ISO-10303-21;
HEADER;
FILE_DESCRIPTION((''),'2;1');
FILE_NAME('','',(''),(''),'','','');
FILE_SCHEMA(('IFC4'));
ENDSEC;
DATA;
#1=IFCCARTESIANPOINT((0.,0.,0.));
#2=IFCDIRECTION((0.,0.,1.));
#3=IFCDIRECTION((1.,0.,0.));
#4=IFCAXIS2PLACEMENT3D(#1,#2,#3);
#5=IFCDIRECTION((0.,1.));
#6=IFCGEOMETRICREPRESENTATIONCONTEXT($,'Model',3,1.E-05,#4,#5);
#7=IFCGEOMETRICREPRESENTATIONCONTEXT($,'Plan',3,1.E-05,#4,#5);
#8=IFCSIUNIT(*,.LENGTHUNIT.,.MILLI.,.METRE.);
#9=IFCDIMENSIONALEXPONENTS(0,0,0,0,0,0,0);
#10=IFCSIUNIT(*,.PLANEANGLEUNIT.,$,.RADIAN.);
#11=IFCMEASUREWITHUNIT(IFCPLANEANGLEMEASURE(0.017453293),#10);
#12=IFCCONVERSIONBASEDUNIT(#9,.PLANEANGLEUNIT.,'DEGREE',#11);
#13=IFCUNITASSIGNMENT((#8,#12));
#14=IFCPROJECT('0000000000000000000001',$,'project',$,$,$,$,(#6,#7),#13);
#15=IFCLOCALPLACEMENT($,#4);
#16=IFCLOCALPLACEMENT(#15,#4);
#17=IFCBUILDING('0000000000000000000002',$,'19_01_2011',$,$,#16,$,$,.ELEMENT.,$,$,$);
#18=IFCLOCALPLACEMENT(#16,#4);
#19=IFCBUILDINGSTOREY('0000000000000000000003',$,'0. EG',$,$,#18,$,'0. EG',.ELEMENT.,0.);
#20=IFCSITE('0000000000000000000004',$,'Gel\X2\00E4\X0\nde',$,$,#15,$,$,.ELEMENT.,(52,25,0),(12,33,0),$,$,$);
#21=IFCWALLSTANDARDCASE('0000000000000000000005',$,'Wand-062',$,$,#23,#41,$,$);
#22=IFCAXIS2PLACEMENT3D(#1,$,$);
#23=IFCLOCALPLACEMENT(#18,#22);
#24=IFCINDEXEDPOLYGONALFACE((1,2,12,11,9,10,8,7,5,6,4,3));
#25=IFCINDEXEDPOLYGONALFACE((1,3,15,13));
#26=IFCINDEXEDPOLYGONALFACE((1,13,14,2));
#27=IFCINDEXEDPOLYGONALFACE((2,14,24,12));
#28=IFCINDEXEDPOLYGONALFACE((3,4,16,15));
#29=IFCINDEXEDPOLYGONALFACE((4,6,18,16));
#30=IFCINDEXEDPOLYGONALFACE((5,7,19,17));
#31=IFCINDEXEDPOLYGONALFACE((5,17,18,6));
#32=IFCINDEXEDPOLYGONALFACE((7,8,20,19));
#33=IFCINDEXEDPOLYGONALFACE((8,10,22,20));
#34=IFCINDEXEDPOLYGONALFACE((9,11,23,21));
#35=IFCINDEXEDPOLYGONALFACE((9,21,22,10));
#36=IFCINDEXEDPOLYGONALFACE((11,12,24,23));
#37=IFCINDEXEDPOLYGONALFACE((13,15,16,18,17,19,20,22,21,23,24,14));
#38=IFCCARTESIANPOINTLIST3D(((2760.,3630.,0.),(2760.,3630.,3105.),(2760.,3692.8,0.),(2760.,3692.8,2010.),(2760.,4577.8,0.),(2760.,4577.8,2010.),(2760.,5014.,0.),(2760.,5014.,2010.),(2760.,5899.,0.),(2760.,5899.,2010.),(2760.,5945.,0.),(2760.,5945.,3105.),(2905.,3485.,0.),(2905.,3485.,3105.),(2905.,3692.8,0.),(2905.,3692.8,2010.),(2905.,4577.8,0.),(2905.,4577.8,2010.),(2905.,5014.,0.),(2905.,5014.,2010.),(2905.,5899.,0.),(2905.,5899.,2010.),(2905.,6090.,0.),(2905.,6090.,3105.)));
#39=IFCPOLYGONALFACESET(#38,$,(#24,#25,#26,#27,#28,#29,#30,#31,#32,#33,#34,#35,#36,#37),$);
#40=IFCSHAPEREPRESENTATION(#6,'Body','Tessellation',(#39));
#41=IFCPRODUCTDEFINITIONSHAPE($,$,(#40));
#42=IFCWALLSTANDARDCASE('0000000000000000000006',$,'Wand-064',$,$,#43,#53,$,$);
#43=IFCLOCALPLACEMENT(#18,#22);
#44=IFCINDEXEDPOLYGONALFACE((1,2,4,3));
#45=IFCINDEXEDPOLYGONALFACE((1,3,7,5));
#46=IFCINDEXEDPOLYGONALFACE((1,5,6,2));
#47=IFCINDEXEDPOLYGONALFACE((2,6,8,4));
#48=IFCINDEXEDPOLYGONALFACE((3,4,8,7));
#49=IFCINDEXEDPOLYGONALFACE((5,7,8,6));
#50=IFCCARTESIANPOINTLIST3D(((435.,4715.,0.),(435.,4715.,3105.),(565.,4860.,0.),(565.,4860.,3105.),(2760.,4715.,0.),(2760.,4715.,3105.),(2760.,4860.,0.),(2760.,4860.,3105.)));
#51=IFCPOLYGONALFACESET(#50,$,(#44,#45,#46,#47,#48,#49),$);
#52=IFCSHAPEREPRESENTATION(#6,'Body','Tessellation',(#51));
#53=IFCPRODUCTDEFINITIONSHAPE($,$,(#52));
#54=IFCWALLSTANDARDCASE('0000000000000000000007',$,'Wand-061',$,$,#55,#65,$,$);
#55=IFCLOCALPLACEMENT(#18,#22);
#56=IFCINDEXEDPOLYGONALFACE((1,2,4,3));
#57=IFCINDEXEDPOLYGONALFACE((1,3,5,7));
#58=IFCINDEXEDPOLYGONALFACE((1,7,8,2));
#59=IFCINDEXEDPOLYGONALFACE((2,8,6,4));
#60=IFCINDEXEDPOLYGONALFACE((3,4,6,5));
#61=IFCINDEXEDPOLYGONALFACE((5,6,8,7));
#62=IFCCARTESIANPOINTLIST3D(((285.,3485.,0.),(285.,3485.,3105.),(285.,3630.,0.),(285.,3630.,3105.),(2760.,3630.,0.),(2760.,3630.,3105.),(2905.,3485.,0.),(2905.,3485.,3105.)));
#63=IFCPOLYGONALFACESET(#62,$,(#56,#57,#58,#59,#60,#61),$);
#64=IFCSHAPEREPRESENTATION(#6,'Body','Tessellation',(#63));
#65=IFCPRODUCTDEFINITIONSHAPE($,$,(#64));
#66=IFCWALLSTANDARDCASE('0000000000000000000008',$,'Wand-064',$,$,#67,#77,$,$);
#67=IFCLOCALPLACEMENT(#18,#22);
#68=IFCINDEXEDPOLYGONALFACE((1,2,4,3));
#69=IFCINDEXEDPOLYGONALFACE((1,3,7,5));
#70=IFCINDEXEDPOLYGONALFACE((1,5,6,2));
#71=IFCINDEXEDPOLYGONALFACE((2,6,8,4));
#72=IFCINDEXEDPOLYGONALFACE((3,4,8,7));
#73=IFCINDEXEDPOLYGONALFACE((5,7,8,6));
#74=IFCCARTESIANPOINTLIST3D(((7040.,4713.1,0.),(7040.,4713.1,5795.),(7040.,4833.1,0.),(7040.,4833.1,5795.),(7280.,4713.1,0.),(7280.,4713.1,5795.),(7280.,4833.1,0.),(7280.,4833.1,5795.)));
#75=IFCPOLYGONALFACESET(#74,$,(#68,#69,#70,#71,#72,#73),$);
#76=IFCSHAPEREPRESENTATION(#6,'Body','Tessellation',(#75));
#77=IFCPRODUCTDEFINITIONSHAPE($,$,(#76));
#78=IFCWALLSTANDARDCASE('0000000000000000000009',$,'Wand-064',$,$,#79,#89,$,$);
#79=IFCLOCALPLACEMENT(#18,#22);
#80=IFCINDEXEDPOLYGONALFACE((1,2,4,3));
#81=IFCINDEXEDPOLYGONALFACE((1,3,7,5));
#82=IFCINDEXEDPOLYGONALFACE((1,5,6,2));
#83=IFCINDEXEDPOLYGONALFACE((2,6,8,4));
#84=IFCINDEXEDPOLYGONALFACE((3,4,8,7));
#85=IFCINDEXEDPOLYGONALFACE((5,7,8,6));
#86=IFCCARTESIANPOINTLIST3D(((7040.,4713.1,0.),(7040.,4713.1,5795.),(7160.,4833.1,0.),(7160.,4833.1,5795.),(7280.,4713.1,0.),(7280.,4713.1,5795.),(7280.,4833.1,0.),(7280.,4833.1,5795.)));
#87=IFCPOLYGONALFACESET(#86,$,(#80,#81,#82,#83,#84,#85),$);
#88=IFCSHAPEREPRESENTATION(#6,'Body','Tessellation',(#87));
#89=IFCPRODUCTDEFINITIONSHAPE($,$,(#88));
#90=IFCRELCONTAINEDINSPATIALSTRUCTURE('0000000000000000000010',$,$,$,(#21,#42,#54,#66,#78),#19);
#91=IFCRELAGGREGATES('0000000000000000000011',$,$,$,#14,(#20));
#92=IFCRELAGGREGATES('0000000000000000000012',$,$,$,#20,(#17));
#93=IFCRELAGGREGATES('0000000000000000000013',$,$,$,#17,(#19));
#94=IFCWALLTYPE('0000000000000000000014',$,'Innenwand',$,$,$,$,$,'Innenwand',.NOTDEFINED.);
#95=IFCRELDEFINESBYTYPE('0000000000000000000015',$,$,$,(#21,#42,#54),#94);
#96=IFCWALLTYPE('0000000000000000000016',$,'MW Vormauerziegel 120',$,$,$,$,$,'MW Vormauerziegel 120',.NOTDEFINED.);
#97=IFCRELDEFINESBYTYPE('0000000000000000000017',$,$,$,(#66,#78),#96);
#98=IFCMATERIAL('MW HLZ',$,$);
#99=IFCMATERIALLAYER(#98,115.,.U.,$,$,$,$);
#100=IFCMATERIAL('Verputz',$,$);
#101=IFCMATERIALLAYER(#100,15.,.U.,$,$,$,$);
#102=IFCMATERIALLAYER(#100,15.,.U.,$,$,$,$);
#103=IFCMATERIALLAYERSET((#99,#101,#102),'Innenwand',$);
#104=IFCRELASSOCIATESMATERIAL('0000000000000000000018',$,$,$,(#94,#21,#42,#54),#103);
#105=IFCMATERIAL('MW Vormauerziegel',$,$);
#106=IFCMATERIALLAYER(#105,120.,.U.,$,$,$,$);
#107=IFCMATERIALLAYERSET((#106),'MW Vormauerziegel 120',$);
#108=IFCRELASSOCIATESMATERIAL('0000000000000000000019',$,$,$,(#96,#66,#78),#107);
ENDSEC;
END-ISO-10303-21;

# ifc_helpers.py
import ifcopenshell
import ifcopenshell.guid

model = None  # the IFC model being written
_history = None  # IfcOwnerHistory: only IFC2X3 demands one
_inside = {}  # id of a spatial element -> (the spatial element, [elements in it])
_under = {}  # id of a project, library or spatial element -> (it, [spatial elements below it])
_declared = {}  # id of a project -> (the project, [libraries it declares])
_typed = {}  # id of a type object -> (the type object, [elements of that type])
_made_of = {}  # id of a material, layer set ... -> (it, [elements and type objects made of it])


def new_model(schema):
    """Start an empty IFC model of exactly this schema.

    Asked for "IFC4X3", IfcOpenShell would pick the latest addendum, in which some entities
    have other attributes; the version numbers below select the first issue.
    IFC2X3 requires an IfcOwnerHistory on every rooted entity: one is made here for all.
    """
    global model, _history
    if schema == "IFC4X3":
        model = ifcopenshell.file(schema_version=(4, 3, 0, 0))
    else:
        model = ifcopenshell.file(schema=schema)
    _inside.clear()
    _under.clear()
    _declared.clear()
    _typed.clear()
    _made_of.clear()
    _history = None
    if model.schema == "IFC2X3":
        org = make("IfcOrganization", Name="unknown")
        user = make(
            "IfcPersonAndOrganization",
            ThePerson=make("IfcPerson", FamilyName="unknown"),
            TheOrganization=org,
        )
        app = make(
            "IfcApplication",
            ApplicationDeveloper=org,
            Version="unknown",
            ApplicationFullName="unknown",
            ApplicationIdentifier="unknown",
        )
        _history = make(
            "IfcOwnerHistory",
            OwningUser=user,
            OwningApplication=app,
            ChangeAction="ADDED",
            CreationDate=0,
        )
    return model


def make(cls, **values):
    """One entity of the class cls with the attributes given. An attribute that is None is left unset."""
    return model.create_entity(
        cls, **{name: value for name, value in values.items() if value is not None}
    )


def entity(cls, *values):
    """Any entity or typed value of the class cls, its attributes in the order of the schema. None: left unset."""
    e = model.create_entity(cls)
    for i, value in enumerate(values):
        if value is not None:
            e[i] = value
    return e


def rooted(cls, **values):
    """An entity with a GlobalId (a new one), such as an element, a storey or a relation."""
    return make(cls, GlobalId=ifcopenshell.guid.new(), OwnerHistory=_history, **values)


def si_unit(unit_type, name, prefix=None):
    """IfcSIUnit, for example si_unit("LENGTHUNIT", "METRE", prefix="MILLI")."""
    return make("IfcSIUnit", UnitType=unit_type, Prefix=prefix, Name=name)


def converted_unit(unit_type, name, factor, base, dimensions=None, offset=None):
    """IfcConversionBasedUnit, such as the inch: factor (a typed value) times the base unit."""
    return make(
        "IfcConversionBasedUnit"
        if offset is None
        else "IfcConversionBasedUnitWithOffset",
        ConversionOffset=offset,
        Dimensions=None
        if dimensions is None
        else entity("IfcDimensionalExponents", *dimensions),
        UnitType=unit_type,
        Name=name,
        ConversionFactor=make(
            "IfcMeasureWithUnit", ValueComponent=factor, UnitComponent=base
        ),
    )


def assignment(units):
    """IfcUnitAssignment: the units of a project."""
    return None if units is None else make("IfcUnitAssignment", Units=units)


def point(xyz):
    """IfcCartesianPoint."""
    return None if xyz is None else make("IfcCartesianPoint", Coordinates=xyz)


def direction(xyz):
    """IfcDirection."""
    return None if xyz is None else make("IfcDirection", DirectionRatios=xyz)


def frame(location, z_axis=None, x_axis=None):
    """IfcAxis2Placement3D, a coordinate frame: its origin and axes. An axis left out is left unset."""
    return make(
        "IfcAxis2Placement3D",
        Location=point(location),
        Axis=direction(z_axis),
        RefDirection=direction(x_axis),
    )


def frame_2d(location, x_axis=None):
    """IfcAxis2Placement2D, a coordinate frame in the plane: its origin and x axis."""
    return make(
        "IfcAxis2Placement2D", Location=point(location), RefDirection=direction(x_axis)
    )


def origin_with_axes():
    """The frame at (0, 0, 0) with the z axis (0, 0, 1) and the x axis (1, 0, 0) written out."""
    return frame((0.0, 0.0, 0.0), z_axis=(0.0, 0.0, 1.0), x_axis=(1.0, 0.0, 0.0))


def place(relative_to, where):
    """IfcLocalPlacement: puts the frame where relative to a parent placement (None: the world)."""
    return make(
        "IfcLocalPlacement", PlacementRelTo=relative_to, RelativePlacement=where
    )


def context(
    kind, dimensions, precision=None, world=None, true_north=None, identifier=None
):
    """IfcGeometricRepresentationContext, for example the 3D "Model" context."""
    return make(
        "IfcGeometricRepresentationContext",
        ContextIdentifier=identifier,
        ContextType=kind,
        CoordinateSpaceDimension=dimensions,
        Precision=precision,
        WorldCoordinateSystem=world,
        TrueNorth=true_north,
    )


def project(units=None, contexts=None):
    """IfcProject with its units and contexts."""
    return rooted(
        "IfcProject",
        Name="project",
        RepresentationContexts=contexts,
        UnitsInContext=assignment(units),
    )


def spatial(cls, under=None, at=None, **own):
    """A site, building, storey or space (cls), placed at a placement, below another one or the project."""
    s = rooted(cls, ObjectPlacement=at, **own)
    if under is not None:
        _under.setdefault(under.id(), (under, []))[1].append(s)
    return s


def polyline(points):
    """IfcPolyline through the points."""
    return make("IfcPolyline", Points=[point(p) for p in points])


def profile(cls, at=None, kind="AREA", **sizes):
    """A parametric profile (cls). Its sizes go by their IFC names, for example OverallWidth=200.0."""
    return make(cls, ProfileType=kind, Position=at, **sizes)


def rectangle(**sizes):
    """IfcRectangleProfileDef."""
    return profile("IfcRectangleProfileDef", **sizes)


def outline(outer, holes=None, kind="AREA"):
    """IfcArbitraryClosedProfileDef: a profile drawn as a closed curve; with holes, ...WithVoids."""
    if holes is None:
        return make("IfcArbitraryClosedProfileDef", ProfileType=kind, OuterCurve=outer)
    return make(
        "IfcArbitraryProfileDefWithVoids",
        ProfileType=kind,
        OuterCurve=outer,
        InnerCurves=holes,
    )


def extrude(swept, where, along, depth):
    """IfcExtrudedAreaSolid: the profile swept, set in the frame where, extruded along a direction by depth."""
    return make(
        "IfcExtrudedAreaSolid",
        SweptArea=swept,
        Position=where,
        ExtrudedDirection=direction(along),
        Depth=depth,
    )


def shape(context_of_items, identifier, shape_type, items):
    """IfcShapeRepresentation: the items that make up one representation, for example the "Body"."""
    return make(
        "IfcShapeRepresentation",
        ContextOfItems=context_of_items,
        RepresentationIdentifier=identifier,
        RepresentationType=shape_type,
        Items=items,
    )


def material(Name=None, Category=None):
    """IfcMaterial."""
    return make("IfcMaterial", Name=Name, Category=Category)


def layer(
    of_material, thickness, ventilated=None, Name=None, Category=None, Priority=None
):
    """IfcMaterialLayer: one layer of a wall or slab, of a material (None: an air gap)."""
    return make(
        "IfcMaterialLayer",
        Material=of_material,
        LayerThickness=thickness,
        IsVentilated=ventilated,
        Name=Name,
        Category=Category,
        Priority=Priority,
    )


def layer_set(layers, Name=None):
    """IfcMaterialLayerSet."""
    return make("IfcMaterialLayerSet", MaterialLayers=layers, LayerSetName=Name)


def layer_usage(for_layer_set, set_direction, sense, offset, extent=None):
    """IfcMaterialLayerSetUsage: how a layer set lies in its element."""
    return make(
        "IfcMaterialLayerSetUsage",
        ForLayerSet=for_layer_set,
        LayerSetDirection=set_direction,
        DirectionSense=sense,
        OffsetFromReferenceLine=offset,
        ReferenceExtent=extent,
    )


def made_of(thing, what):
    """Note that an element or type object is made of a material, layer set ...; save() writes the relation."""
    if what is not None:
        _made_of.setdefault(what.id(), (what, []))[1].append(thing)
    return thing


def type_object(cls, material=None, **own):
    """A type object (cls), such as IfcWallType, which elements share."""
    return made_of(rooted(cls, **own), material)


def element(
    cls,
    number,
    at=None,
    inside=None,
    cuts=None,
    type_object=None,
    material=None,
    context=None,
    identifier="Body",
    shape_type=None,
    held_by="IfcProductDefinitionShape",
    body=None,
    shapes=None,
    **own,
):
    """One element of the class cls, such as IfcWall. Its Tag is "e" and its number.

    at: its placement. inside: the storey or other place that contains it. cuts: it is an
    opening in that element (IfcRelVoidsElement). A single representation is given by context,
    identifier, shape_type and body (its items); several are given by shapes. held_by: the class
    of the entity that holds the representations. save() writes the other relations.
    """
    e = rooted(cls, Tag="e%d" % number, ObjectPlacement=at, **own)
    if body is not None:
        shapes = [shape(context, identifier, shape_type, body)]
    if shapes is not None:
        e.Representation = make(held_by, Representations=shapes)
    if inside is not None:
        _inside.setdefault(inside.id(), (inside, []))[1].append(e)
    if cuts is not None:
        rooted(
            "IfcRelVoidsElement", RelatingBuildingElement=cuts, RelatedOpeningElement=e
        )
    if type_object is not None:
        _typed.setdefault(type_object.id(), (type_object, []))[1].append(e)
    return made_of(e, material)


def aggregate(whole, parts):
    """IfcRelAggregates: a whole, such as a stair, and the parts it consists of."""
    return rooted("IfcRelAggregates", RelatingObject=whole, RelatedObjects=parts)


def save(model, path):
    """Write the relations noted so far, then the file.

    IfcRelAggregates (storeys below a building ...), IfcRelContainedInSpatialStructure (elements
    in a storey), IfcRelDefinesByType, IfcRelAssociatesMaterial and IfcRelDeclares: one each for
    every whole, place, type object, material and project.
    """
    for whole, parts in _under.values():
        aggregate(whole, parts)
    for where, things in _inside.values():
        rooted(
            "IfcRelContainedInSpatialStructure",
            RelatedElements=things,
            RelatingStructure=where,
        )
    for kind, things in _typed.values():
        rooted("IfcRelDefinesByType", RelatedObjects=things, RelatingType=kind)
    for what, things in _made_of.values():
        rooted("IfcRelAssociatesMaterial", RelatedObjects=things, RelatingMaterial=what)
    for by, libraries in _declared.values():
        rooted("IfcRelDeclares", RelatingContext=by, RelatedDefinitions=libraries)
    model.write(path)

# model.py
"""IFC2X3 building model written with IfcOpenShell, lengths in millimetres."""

from ifc_helpers import new_model, entity, si_unit, converted_unit, direction, frame, frame_2d, origin_with_axes, place, context, project, spatial, polyline, rectangle, outline, extrude, material, layer, layer_set, layer_usage, type_object, element, save


model = new_model("IFC2X3")

# Units and contexts
model_context = context("Model", 3, precision=1e-05, world=origin_with_axes(), true_north=direction((0.0, 1.0)))
plan_context = context("Plan", 3, precision=1e-05, world=origin_with_axes(), true_north=direction((0.0, 1.0)))
ifc_project = project(units=[si_unit("LENGTHUNIT", "METRE", prefix="MILLI"), converted_unit("PLANEANGLEUNIT", "DEGREE", entity("IfcPlaneAngleMeasure", 0.017453293), si_unit("PLANEANGLEUNIT", "RADIAN"), dimensions=[0, 0, 0, 0, 0, 0, 0])], contexts=[model_context, plan_context])

# Site, building, storey
site_placement = place(None, origin_with_axes())
site = spatial("IfcSite", under=ifc_project, at=site_placement, Name="Gelände", CompositionType="ELEMENT", RefLatitude=(52, 25, 0), RefLongitude=(12, 33, 0))
building_placement = place(site_placement, origin_with_axes())
building = spatial("IfcBuilding", under=site, at=building_placement, Name="19_01_2011", CompositionType="ELEMENT")
storey_placement = place(building_placement, origin_with_axes())
storey = spatial("IfcBuildingStorey", under=building, at=storey_placement, Name="0. EG", LongName="0. EG", CompositionType="ELEMENT", Elevation=0.0)

# Shared definitions
ifc_material_1 = material(Name="MW HLZ")
ifc_material_2 = material(Name="Verputz")

# Wall, openings
ifc_material_3 = material(Name="MW Vormauerziegel")
ifc_layer_1 = layer(ifc_material_1, 115.0, ventilated="UNKNOWN")
ifc_layer_2 = layer(ifc_material_2, 15.0, ventilated="UNKNOWN")
ifc_layer_3 = layer(ifc_material_2, 15.0, ventilated="UNKNOWN")
ifc_layer_set_1 = layer_set([ifc_layer_1, ifc_layer_2, ifc_layer_3], Name="Innenwand")
ifc_layer_usage_1 = layer_usage(ifc_layer_set_1, "AXIS2", "NEGATIVE", 0.0)
wall_type_1 = type_object("IfcWallType", Name="Innenwand", ElementType="Innenwand", PredefinedType="NOTDEFINED", material=ifc_layer_set_1)
wall_1_placement = place(storey_placement, frame((2760.0, 3630.0, 0.0), z_axis=(0.0, 0.0, 1.0), x_axis=(0.0, 1.0, 0.0)))
wall_1 = element("IfcWallStandardCase", 1, at=wall_1_placement, inside=storey, type_object=wall_type_1, material=ifc_layer_usage_1, Name="Wand-062", context=model_context, shape_type="SweptSolid", body=[
    extrude(outline(polyline([(-145.0, -145.0), (2460.0, -145.0), (2315.0, 0.0), (0.0, 0.0), (-145.0, -145.0)])), origin_with_axes(), (0.0, 0.0, 1.0), 3105.0),
])
opening_1_placement = place(wall_1_placement, frame((505.3, -145.0, 0.0), z_axis=(0.0, 0.0, 1.0), x_axis=(1.0, 0.0, 0.0)))
element("IfcOpeningElement", 2, at=opening_1_placement, cuts=wall_1, ObjectType="Opening", context=model_context, shape_type="SweptSolid", body=[
    extrude(rectangle(XDim=885.0, YDim=2010.0, at=frame_2d((0.0, 1005.0), x_axis=(-1.0, 0.0))), frame((0.0, 0.0, 0.0), z_axis=(0.0, 1.0, 0.0), x_axis=(-1.0, 0.0, 0.0)), (0.0, 0.0, 1.0), 145.0),
])
opening_2_placement = place(wall_1_placement, frame((1826.5, -145.0, 0.0), z_axis=(0.0, 0.0, 1.0), x_axis=(1.0, 0.0, 0.0)))
element("IfcOpeningElement", 3, at=opening_2_placement, cuts=wall_1, ObjectType="Opening", context=model_context, shape_type="SweptSolid", body=[
    extrude(rectangle(XDim=885.0, YDim=2010.0, at=frame_2d((0.0, 1005.0), x_axis=(-1.0, 0.0))), frame((0.0, 0.0, 0.0), z_axis=(0.0, 1.0, 0.0), x_axis=(-1.0, 0.0, 0.0)), (0.0, 0.0, 1.0), 145.0),
])

# Walls
ifc_layer_usage_2 = layer_usage(ifc_layer_set_1, "AXIS2", "NEGATIVE", 0.0)
wall_2_placement = place(storey_placement, frame((2760.0, 4715.0, 0.0), z_axis=(0.0, 0.0, 1.0), x_axis=(-1.0, 0.0, 0.0)))
element("IfcWallStandardCase", 4, at=wall_2_placement, inside=storey, type_object=wall_type_1, material=ifc_layer_usage_2, Name="Wand-064", context=model_context, shape_type="SweptSolid", body=[
    extrude(outline(polyline([(0.0, -145.0), (2195.0, -145.0), (2325.0, 0.0), (0.0, 0.0), (0.0, -145.0)])), origin_with_axes(), (0.0, 0.0, 1.0), 3105.0),
])
ifc_layer_usage_3 = layer_usage(ifc_layer_set_1, "AXIS2", "NEGATIVE", 0.0)
wall_3_placement = place(storey_placement, frame((285.0, 3630.0, 0.0), z_axis=(0.0, 0.0, 1.0), x_axis=(1.0, 0.0, 0.0)))
element("IfcWallStandardCase", 5, at=wall_3_placement, inside=storey, type_object=wall_type_1, material=ifc_layer_usage_3, Name="Wand-061", context=model_context, shape_type="SweptSolid", body=[
    extrude(outline(polyline([(0.0, -145.0), (2620.0, -145.0), (2475.0, 0.0), (0.0, 0.0), (0.0, -145.0)])), origin_with_axes(), (0.0, 0.0, 1.0), 3105.0),
])
ifc_layer_4 = layer(ifc_material_3, 120.0, ventilated="UNKNOWN")
ifc_layer_set_2 = layer_set([ifc_layer_4], Name="MW Vormauerziegel 120")
wall_type_2 = type_object("IfcWallType", Name="MW Vormauerziegel 120", ElementType="MW Vormauerziegel 120", PredefinedType="NOTDEFINED", material=ifc_layer_set_2)
ifc_layer_usage_4 = layer_usage(ifc_layer_set_2, "AXIS2", "POSITIVE", 0.0)
wall_4_placement = place(storey_placement, frame((7040.0, 4713.1, 0.0), z_axis=(0.0, 0.0, 1.0), x_axis=(1.0, 0.0, 0.0)))
element("IfcWallStandardCase", 6, at=wall_4_placement, inside=storey, type_object=wall_type_2, material=ifc_layer_usage_4, Name="Wand-064", context=model_context, shape_type="SweptSolid", body=[
    extrude(outline(polyline([(0.0, 0.0), (240.0, 0.0), (240.0, 120.0), (0.0, 120.0), (0.0, 0.0)])), origin_with_axes(), (0.0, 0.0, 1.0), 5795.0),
])
ifc_layer_usage_5 = layer_usage(ifc_layer_set_2, "AXIS2", "POSITIVE", 0.0)
wall_5_placement = place(storey_placement, frame((7040.0, 4713.1, 0.0), z_axis=(0.0, 0.0, 1.0), x_axis=(1.0, 0.0, 0.0)))
element("IfcWallStandardCase", 7, at=wall_5_placement, inside=storey, type_object=wall_type_2, material=ifc_layer_usage_5, Name="Wand-064", context=model_context, shape_type="SweptSolid", body=[
    extrude(outline(polyline([(0.0, 0.0), (240.0, 0.0), (240.0, 120.0), (120.0, 120.0), (0.0, 0.0)])), origin_with_axes(), (0.0, 0.0, 1.0), 5795.0),
])

save(model, "model.ifc")
